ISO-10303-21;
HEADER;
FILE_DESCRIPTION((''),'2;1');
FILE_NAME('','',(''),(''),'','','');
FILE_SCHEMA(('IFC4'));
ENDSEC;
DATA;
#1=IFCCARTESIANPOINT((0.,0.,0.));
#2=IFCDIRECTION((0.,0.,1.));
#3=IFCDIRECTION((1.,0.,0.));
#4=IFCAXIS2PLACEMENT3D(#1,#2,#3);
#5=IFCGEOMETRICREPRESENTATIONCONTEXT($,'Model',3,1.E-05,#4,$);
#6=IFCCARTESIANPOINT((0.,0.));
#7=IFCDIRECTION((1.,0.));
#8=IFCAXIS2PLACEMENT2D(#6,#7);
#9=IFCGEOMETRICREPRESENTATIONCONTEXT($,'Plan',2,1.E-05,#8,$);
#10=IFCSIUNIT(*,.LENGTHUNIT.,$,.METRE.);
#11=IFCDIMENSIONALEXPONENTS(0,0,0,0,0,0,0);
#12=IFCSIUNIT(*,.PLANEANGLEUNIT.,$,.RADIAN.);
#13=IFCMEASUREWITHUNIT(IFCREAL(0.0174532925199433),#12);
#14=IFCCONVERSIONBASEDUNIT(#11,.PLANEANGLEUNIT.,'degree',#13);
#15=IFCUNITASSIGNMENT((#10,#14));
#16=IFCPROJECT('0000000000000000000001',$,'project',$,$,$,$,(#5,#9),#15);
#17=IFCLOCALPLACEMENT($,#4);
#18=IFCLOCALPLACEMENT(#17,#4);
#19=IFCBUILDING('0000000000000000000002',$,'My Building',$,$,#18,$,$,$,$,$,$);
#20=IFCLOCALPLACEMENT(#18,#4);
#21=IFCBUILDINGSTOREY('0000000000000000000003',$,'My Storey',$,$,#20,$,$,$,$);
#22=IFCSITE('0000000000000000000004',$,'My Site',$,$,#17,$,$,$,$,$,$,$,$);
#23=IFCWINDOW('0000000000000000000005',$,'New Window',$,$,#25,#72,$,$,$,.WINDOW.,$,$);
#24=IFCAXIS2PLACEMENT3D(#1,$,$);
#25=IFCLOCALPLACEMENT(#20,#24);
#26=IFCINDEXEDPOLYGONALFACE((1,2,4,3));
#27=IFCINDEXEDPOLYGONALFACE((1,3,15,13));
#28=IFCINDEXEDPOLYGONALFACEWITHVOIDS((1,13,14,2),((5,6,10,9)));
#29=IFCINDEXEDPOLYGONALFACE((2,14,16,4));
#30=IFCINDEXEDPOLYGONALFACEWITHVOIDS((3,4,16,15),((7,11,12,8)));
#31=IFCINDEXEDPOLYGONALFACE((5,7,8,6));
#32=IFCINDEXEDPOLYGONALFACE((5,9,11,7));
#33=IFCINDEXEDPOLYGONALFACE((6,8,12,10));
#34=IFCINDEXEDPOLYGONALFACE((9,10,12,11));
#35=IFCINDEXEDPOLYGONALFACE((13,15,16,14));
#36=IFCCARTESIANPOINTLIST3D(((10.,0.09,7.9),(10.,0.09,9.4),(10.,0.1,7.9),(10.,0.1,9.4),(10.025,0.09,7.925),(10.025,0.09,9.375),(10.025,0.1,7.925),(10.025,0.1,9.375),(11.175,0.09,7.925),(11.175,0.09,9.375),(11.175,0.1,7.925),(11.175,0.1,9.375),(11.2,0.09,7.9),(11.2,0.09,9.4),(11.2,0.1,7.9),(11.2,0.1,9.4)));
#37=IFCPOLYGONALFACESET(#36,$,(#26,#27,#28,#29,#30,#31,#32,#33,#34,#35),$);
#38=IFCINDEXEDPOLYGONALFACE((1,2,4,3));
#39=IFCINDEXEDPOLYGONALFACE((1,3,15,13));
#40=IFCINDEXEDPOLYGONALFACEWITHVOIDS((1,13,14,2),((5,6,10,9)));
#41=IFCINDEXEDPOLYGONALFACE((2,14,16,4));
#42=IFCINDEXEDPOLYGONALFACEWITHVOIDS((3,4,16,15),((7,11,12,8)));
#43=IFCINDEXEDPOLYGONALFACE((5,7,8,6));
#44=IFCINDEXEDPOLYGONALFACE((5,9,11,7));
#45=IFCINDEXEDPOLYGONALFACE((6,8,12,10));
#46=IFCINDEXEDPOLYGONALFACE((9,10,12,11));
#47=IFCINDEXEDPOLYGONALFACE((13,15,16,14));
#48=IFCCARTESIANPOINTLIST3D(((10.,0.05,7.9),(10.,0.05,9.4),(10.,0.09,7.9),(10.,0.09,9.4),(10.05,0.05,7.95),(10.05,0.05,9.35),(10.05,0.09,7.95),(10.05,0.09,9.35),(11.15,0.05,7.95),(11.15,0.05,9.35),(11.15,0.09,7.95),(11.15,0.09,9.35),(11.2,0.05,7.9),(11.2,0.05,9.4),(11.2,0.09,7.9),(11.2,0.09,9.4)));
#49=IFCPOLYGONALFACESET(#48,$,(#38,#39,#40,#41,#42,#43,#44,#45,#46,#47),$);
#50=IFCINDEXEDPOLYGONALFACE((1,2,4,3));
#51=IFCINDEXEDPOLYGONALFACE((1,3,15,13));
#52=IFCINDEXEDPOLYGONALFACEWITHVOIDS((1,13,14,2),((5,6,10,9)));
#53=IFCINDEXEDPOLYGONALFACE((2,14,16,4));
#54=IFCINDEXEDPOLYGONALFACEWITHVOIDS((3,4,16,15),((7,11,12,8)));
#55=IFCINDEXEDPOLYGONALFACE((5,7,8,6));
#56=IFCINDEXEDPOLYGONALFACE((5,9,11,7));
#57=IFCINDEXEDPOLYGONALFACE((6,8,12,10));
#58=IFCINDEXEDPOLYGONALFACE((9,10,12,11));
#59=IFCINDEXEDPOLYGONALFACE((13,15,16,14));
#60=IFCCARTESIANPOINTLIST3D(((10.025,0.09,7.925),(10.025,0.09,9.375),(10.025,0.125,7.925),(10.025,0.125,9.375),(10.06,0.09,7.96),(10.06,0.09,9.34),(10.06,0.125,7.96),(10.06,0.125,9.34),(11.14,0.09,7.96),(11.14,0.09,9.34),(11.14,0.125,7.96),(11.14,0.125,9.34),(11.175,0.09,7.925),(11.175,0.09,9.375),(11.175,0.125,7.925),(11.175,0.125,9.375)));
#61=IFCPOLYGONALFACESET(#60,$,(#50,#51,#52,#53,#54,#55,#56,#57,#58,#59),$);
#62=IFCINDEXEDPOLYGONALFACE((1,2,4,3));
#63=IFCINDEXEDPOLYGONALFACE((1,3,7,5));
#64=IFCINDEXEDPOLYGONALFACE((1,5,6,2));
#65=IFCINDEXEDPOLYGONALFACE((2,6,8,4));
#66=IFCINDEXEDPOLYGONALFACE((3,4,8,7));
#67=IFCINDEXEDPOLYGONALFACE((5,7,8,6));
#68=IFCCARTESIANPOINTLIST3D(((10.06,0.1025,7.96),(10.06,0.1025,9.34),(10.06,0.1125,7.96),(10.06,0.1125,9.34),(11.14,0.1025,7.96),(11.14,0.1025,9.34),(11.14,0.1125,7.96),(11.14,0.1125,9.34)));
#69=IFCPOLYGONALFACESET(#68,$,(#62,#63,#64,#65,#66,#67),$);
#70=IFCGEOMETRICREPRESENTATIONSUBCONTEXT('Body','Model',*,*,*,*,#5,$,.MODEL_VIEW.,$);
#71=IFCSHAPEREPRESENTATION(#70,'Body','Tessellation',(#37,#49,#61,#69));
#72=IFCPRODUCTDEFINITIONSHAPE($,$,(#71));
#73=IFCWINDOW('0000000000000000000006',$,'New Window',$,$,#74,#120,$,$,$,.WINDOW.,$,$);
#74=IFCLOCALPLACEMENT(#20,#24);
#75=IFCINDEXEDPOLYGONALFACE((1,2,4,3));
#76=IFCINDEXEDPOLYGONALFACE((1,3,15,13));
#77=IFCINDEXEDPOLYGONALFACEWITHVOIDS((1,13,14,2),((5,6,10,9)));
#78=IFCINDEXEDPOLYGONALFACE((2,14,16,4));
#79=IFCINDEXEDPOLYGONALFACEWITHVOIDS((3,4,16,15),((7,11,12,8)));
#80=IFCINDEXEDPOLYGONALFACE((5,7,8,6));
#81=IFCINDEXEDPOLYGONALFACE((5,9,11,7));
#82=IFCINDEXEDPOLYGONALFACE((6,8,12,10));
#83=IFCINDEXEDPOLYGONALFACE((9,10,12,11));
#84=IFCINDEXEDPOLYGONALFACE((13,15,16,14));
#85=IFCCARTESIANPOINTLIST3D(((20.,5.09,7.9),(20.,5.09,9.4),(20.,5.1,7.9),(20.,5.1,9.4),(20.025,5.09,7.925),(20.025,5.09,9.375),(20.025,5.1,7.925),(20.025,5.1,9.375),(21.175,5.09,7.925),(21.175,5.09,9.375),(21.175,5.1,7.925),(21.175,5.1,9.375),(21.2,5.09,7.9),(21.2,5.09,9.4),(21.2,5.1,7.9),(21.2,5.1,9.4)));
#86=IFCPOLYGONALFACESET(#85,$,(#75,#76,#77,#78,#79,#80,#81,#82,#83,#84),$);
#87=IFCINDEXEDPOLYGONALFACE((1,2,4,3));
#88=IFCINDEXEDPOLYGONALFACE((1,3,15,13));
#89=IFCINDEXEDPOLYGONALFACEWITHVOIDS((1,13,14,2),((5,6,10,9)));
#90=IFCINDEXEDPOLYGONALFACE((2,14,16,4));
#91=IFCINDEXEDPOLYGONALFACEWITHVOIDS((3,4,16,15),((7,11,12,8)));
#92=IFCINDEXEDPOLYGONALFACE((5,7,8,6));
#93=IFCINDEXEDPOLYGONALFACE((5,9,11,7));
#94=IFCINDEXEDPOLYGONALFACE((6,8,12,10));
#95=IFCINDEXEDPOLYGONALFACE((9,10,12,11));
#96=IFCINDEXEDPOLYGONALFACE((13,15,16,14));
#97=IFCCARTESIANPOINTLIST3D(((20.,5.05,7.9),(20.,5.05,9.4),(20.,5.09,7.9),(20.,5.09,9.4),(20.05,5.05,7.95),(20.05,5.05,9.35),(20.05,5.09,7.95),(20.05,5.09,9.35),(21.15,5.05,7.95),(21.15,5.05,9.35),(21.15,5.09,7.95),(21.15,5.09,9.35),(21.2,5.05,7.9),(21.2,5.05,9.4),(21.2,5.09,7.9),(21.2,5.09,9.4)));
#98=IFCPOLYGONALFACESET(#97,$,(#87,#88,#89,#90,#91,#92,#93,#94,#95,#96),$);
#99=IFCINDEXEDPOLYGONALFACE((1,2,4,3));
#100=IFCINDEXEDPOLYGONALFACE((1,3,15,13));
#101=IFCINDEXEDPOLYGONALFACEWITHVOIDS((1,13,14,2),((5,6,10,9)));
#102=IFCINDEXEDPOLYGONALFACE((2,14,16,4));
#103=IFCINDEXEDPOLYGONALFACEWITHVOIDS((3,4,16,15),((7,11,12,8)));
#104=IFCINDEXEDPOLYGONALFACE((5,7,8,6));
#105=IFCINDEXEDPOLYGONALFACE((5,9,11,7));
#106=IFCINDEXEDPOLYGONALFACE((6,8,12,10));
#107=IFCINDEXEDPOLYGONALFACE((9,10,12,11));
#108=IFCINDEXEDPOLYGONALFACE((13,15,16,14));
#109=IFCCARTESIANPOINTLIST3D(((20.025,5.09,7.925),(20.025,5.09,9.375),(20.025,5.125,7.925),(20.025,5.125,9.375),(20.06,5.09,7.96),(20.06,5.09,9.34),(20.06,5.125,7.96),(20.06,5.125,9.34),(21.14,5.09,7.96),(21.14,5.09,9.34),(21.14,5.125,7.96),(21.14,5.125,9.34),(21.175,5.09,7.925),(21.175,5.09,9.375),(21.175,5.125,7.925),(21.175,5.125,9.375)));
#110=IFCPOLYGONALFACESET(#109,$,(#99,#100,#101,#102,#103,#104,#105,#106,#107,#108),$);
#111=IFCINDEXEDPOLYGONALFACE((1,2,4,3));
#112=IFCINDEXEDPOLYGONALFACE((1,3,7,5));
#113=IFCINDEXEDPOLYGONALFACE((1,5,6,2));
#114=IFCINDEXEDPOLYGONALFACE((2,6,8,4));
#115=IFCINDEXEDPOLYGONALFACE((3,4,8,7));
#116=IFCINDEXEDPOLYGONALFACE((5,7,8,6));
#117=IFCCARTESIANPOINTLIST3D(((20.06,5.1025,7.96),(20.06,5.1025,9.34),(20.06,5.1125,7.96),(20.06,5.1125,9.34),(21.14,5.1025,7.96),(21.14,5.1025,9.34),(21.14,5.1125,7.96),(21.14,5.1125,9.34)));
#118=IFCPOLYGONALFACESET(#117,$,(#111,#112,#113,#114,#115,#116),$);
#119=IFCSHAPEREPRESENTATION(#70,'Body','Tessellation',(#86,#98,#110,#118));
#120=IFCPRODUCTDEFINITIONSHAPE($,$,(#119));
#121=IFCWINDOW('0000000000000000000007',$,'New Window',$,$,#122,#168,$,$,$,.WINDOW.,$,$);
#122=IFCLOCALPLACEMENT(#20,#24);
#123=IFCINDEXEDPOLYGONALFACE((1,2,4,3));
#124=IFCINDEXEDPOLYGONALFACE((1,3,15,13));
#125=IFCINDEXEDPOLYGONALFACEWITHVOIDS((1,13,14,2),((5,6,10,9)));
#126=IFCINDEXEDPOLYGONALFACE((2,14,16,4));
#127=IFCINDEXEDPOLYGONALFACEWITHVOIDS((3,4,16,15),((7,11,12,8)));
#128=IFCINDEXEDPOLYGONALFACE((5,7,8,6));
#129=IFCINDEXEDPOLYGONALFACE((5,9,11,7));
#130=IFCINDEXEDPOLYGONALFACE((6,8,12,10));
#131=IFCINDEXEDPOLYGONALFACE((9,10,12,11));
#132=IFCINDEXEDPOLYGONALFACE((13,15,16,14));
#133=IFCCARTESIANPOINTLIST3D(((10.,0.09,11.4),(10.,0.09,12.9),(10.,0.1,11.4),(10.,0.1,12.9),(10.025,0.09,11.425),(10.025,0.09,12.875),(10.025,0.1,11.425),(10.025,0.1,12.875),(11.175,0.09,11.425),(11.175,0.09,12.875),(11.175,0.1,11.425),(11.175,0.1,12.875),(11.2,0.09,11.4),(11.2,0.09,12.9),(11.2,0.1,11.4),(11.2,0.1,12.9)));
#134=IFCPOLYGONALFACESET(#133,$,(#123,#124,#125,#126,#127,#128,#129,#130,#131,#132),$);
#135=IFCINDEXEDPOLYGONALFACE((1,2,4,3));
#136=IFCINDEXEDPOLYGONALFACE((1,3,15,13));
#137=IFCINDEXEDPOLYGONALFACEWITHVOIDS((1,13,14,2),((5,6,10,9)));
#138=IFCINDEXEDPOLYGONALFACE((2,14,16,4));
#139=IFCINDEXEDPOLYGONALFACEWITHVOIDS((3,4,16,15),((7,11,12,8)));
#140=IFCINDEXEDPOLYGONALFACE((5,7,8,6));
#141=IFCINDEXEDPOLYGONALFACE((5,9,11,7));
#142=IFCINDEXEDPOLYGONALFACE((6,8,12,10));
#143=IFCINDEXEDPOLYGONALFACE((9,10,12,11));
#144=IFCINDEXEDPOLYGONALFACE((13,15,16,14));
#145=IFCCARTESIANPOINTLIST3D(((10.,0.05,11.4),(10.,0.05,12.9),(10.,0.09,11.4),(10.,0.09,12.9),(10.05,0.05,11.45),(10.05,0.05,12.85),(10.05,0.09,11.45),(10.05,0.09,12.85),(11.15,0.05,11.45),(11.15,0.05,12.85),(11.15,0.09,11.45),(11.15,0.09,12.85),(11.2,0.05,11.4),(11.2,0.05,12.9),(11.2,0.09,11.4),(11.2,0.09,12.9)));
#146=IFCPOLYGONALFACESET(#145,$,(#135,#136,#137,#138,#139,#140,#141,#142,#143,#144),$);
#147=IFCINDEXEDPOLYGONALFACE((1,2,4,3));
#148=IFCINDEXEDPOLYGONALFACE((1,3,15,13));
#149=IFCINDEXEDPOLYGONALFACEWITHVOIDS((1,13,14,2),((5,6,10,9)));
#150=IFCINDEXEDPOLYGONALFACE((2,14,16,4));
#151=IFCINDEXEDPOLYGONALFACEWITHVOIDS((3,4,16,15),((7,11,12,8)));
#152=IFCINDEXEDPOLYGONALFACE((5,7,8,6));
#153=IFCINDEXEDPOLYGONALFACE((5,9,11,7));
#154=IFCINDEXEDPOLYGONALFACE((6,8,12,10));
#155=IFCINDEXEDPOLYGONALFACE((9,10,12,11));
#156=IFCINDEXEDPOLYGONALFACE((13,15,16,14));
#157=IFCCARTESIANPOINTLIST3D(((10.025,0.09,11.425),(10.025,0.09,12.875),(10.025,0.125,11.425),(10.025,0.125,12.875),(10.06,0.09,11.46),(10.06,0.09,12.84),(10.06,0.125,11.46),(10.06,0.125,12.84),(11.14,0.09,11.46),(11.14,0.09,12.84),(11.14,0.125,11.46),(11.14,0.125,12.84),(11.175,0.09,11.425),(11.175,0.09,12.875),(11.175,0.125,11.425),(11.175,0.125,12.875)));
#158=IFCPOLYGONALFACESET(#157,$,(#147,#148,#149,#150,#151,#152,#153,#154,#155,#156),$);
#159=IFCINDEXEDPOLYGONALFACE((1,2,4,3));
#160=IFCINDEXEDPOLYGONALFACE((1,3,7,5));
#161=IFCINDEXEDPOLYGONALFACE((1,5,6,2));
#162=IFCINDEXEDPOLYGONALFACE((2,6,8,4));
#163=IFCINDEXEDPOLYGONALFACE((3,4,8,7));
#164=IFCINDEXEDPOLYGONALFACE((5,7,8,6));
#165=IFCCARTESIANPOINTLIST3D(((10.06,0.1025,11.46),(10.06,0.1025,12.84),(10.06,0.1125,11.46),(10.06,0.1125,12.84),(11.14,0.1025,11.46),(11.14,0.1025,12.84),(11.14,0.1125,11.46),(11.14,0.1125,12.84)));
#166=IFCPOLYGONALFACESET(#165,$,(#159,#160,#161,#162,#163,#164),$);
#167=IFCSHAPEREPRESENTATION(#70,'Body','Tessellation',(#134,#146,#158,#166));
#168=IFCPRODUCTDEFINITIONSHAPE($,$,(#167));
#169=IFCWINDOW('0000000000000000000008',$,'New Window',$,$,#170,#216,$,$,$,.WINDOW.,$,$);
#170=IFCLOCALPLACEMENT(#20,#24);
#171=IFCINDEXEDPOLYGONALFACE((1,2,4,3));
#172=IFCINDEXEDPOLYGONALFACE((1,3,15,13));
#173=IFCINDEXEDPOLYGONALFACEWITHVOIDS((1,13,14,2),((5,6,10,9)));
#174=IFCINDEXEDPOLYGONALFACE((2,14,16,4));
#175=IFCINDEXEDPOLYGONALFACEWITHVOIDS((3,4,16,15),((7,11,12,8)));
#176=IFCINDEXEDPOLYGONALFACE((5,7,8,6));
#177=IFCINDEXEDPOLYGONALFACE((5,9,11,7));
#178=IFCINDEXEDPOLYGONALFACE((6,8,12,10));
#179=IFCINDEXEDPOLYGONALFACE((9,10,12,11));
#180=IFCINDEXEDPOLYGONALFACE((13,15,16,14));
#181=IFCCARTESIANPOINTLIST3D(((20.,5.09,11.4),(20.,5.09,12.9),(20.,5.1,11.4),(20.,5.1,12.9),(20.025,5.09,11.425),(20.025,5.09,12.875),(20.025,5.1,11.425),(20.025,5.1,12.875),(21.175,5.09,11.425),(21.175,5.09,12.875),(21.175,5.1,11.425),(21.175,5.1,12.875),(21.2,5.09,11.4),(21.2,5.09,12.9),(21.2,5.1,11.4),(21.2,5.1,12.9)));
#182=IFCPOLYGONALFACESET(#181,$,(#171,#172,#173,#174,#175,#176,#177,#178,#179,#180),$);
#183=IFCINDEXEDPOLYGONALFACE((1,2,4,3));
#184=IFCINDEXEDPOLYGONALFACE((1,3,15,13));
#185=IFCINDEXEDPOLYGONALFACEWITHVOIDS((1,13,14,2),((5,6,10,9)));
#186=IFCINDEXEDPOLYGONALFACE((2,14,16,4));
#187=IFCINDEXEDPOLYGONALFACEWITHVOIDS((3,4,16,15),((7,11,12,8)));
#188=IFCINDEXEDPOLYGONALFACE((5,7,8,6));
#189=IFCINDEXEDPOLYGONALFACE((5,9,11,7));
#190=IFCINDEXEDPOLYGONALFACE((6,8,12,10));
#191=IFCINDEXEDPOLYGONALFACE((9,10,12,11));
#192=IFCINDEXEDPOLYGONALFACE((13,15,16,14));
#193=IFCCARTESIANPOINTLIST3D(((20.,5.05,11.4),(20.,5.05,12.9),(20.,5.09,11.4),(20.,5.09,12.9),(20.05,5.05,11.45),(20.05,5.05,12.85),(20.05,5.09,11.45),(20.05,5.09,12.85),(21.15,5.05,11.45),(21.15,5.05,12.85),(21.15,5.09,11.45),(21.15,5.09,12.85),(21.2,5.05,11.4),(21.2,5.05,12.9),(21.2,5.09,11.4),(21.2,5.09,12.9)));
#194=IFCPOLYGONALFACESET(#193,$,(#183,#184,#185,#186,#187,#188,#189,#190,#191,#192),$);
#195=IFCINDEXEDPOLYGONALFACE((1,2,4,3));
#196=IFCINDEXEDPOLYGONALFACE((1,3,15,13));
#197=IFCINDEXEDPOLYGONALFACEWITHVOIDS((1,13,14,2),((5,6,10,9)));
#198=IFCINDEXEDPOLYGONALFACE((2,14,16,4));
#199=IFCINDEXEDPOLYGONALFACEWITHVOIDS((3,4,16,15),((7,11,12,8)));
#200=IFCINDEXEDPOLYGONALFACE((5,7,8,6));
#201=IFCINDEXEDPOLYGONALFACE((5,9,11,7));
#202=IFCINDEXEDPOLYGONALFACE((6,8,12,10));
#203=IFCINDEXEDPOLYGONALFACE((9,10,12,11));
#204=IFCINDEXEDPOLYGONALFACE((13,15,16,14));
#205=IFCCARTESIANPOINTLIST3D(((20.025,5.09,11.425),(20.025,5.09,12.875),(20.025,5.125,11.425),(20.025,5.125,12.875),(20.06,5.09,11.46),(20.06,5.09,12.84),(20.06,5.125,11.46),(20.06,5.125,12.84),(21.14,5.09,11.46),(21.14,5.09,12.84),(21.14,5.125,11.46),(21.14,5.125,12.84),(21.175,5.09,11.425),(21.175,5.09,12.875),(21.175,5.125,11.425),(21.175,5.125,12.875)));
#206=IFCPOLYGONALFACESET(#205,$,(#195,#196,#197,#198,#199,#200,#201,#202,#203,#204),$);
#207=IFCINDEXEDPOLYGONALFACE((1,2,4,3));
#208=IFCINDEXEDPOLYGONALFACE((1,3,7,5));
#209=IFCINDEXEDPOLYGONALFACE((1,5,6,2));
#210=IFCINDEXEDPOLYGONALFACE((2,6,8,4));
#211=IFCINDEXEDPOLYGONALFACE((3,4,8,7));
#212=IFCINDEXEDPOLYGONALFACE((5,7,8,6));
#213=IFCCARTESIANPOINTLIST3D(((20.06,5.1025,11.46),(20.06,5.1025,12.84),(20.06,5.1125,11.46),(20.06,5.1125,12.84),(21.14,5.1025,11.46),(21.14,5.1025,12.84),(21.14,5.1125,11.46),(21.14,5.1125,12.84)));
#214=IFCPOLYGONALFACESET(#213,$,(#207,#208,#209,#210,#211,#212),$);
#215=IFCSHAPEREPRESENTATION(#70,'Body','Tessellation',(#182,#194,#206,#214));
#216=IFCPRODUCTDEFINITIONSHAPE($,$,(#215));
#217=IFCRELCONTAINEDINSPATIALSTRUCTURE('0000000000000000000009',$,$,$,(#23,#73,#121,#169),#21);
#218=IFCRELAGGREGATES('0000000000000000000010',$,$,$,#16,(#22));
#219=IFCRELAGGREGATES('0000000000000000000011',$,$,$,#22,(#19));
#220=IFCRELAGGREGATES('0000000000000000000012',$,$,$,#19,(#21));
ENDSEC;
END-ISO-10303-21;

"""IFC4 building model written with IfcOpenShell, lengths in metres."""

from ifc_helpers import new_model, entity, si_unit, converted_unit, frame, origin_with_axes, origin_2d_with_axis, place, context, subcontext, project, spatial, line, indexed_curve, outline, extrude, element, save


model = new_model("IFC4")

# Units and contexts
model_context = context("Model", 3, precision=1e-05, world=origin_with_axes())
plan_context = context("Plan", 2, precision=1e-05, world=origin_2d_with_axis())
body_context = subcontext(model_context, "Body", "Model", "MODEL_VIEW")
ifc_project = project(units=[si_unit("LENGTHUNIT", "METRE"), converted_unit("PLANEANGLEUNIT", "degree", entity("IfcReal", 0.0174532925199433), si_unit("PLANEANGLEUNIT", "RADIAN"), dimensions=[0, 0, 0, 0, 0, 0, 0])], contexts=[model_context, plan_context])

# Site, building, storey
site_placement = place(None, origin_with_axes())
site = spatial("IfcSite", under=ifc_project, at=site_placement, Name="My Site")
building_placement = place(site_placement, origin_with_axes())
building = spatial("IfcBuilding", under=site, at=building_placement, Name="My Building")
storey_placement = place(building_placement, origin_with_axes())
storey = spatial("IfcBuildingStorey", under=building, at=storey_placement, Name="My Storey")

# Windows
for number, where, z_axis, x_axis, name in (
    (1, (10.0, 0.0, 7.9), (0.0, 0.0, 1.0), (1.0, 0.0, 0.0), "New Window"),
    (2, (20.0, 5.0, 7.9), (0.0, 0.0, 1.0), (1.0, 0.0, 0.0), "New Window"),
    (3, (10.0, 0.0, 11.4), (0.0, 0.0, 1.0), (1.0, 0.0, 0.0), "New Window"),
    (4, (20.0, 5.0, 11.4), (0.0, 0.0, 1.0), (1.0, 0.0, 0.0), "New Window"),
):
    element("IfcWindow", number, at=place(storey_placement, frame(where, z_axis=z_axis, x_axis=x_axis)), inside=storey, Name=name, PredefinedType="WINDOW", context=body_context, shape_type="SweptSolid", body=[
        extrude(outline(indexed_curve([(0.0, 0.0), (1.2, 0.0), (1.2, 1.5), (0.0, 1.5)], segments=[line(1, 2, 3, 4, 1)]), holes=[indexed_curve([(0.025, 0.025), (1.175, 0.025), (1.175, 1.475), (0.025, 1.475)], segments=[line(1, 2, 3, 4, 1)])]), frame((0.0, 0.09, 0.0), z_axis=(0.0, -1.0, 0.0), x_axis=(1.0, 0.0, 0.0)), (0.0, 0.0, -1.0), 0.01),
        extrude(outline(indexed_curve([(0.0, 0.0), (1.2, 0.0), (1.2, 1.5), (0.0, 1.5)], segments=[line(1, 2, 3, 4, 1)]), holes=[indexed_curve([(0.05, 0.05), (1.15, 0.05), (1.15, 1.45), (0.05, 1.45)], segments=[line(1, 2, 3, 4, 1)])]), frame((0.0, 0.05, 0.0), z_axis=(0.0, -1.0, 0.0), x_axis=(1.0, 0.0, 0.0)), (0.0, 0.0, -1.0), 0.04),
        extrude(outline(indexed_curve([(0.0, 0.0), (1.15, 0.0), (1.15, 1.45), (0.0, 1.45)], segments=[line(1, 2, 3, 4, 1)]), holes=[indexed_curve([(0.035, 0.035), (1.115, 0.035), (1.115, 1.415), (0.035, 1.415)], segments=[line(1, 2, 3, 4, 1)])]), frame((0.025, 0.09, 0.025), z_axis=(0.0, -1.0, 0.0), x_axis=(1.0, 0.0, 0.0)), (0.0, 0.0, -1.0), 0.035),
        extrude(outline(indexed_curve([(0.035, 0.035), (1.115, 0.035), (1.115, 1.415), (0.035, 1.415)], segments=[line(1, 2, 3, 4, 1)])), frame((0.025, 0.1025, 0.025), z_axis=(0.0, -1.0, 0.0), x_axis=(1.0, 0.0, 0.0)), (0.0, 0.0, -1.0), 0.01),
    ])

save(model, "model.ifc")
